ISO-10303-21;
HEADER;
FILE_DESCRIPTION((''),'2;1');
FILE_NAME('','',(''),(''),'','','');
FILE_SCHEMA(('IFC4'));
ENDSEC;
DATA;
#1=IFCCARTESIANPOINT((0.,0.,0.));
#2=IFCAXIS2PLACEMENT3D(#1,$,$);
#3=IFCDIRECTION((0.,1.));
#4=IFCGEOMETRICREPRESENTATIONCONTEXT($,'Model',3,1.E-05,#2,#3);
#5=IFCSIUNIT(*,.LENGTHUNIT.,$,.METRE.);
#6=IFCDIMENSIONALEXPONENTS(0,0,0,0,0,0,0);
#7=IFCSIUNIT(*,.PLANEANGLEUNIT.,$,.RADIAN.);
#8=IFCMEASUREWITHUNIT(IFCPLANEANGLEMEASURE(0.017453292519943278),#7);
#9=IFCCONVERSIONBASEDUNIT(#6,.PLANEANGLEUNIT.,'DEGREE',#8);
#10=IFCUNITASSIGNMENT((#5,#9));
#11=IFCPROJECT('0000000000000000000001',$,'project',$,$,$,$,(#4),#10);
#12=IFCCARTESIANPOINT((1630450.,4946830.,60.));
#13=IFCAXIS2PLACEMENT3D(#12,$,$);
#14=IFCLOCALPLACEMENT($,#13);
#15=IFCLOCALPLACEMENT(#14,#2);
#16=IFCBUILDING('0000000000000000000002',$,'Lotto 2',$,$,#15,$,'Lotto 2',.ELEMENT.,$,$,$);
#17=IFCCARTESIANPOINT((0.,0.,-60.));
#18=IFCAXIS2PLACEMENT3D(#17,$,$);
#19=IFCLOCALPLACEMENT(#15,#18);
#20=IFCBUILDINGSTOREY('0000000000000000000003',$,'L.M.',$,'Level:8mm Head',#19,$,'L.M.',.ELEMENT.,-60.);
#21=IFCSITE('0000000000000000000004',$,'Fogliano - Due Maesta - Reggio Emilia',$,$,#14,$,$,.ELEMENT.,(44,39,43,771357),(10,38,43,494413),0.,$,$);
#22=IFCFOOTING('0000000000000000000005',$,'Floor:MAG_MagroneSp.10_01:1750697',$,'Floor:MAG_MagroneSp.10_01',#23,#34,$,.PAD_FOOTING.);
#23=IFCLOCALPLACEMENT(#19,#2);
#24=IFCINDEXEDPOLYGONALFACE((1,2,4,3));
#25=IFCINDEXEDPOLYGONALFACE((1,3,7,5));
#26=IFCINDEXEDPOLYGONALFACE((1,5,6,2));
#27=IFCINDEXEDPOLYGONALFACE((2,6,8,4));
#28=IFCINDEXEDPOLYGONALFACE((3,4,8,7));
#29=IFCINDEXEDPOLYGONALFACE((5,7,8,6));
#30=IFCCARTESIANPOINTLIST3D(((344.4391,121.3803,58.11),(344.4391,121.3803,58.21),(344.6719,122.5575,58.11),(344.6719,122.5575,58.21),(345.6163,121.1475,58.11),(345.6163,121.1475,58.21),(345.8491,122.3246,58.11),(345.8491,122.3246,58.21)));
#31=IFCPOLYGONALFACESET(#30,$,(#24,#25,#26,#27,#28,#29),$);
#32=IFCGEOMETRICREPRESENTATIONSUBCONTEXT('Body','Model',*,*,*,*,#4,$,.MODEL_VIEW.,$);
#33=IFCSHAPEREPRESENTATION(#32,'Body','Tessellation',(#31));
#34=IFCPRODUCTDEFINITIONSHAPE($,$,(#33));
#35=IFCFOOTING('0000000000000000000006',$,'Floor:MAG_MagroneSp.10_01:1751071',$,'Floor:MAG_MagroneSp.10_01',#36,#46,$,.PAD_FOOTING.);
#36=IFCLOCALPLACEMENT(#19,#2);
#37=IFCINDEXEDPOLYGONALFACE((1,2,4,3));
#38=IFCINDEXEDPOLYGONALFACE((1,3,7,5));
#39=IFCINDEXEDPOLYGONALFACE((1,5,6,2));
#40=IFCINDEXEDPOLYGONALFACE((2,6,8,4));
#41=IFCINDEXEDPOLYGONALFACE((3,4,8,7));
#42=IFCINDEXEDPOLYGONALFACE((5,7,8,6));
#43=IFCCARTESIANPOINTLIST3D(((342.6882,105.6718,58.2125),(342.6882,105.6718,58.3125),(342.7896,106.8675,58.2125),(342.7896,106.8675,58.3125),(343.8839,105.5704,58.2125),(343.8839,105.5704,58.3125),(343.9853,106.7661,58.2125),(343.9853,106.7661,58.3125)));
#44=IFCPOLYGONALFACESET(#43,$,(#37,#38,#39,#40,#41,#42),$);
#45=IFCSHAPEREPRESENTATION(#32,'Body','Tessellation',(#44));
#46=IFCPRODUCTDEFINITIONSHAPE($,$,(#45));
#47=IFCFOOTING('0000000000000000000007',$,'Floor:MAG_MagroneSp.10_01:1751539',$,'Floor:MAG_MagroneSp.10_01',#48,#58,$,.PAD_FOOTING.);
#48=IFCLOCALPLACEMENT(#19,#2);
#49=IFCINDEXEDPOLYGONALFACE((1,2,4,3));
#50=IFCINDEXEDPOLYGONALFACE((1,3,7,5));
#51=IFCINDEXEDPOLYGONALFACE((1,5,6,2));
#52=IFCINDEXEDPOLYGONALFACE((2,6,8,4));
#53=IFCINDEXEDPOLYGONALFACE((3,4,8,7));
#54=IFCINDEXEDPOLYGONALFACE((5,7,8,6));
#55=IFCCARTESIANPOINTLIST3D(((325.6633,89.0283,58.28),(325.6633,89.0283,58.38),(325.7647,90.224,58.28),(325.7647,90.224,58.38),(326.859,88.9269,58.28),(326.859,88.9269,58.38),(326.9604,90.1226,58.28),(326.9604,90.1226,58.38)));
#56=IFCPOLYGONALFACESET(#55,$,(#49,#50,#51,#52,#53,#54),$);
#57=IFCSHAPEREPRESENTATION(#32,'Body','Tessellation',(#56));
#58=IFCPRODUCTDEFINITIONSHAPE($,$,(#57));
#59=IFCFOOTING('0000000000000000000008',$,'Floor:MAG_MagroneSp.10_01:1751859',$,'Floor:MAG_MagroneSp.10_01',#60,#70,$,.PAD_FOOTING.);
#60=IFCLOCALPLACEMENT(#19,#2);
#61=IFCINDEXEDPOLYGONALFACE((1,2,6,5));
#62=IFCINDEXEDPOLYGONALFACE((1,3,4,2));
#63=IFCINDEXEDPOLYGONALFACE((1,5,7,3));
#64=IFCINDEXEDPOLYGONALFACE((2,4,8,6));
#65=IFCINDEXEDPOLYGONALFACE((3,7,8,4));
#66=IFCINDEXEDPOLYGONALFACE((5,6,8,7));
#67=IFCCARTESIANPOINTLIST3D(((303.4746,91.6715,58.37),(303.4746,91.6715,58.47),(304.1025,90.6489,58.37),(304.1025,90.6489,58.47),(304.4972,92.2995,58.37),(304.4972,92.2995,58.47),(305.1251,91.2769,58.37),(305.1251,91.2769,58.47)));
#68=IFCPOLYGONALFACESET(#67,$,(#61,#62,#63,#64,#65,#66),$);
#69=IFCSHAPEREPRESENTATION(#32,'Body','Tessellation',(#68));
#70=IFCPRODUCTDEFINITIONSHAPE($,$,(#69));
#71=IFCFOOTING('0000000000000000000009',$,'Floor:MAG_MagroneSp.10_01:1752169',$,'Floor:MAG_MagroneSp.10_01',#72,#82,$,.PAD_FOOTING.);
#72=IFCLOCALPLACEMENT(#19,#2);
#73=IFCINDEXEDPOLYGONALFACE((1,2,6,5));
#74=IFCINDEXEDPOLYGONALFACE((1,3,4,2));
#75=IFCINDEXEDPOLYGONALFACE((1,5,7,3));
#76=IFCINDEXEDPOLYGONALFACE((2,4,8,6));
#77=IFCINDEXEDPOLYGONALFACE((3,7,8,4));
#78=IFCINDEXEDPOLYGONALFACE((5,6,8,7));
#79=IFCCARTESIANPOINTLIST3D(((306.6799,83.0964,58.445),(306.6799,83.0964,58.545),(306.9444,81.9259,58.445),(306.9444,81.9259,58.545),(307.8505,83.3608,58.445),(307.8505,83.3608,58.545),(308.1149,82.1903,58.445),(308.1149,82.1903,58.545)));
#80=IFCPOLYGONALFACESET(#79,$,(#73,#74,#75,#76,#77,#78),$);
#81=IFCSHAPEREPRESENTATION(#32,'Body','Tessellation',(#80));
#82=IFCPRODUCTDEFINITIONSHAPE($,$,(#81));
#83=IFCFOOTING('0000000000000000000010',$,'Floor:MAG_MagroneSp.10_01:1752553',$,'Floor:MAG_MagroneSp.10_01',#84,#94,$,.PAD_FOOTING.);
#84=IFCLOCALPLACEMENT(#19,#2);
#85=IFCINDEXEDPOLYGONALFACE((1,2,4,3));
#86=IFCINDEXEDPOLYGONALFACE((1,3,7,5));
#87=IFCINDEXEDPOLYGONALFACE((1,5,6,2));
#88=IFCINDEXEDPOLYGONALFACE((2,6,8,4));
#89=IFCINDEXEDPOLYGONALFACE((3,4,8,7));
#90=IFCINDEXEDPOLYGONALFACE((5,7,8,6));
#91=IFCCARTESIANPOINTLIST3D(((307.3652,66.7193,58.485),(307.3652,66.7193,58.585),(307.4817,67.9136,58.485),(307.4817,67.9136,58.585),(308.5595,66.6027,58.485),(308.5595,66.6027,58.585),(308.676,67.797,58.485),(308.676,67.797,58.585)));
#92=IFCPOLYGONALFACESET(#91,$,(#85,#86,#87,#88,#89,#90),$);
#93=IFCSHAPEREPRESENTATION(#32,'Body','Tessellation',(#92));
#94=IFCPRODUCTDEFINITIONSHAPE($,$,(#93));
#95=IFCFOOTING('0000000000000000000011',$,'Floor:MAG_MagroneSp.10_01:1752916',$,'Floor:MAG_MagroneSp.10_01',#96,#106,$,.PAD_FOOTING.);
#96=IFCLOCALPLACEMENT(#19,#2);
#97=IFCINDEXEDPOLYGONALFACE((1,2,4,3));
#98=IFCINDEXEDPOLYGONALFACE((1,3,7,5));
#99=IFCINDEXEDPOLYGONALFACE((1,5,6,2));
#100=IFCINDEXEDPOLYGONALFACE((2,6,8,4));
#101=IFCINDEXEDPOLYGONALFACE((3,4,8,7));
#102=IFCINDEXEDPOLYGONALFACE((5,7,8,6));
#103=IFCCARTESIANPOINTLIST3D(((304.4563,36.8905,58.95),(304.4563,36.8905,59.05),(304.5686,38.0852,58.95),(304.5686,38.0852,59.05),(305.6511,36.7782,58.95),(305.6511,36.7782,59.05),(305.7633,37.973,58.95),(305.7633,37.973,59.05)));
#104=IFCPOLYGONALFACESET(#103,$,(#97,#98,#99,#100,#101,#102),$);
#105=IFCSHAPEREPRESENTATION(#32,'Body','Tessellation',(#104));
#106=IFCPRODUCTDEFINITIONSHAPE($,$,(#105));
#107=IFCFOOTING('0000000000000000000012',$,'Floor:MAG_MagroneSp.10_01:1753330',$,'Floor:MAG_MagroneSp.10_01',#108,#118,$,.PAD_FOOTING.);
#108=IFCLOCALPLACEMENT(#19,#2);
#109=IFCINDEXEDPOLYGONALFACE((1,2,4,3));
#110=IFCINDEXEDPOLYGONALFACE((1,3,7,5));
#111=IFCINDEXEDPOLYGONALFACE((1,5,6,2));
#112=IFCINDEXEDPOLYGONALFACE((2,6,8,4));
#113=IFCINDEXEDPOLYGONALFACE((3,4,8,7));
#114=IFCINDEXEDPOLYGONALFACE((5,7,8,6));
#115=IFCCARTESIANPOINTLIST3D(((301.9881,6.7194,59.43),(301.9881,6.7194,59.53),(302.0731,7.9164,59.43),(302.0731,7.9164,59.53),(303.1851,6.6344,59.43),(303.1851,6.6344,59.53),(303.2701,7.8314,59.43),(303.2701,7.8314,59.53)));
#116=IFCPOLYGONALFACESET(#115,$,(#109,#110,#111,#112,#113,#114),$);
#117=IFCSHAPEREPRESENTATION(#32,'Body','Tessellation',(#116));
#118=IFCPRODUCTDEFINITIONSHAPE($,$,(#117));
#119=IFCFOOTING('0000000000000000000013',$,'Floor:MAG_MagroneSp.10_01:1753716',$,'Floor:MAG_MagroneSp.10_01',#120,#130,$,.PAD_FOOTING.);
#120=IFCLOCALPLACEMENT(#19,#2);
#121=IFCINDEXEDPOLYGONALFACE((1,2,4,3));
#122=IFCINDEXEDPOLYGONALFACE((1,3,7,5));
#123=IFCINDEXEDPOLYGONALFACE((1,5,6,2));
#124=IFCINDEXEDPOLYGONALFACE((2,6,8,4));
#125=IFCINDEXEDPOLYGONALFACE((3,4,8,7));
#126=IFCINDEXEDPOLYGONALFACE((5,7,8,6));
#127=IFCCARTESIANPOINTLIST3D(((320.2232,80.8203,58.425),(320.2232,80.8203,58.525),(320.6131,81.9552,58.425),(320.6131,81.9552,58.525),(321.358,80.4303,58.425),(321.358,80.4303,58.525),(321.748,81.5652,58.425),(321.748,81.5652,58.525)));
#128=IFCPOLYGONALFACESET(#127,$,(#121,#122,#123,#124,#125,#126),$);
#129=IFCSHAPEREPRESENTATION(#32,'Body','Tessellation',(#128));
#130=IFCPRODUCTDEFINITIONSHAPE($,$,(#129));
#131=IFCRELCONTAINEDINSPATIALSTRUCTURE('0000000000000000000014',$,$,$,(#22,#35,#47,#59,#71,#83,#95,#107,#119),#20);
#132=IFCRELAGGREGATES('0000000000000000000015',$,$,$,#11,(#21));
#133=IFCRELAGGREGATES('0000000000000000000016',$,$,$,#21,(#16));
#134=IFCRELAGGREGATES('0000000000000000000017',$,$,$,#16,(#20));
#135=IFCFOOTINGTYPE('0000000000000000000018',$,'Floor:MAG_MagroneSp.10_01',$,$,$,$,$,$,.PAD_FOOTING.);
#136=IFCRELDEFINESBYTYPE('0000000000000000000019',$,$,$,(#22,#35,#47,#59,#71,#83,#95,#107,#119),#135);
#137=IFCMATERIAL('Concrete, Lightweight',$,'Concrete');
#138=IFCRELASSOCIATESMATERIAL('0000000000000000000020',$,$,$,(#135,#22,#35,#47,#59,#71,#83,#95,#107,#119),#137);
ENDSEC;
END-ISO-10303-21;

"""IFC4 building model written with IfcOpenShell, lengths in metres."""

from ifc_helpers import new_model, entity, si_unit, converted_unit, direction, frame, origin, place, context, subcontext, project, spatial, indexed_curve, outline, extrude, material, type_object, element, save


model = new_model("IFC4")

# Units and contexts
model_context = context("Model", 3, precision=1e-05, world=origin(), true_north=direction((0.0, 1.0)))
body_context = subcontext(model_context, "Body", "Model", "MODEL_VIEW")
ifc_project = project(units=[si_unit("LENGTHUNIT", "METRE"), converted_unit("PLANEANGLEUNIT", "DEGREE", entity("IfcPlaneAngleMeasure", 0.017453292519943278), si_unit("PLANEANGLEUNIT", "RADIAN"), dimensions=[0, 0, 0, 0, 0, 0, 0])], contexts=[model_context])

# Site, building, storey
site_placement = place(None, frame((1630450.0, 4946830.0, 60.0)))
site = spatial("IfcSite", under=ifc_project, at=site_placement, Name="Fogliano - Due Maesta - Reggio Emilia", CompositionType="ELEMENT", RefLatitude=(44, 39, 43, 771357), RefLongitude=(10, 38, 43, 494413), RefElevation=0.0)
building_placement = place(site_placement, origin())
building = spatial("IfcBuilding", under=site, at=building_placement, Name="Lotto 2", LongName="Lotto 2", CompositionType="ELEMENT")
storey_placement = place(building_placement, frame((0.0, 0.0, -60.0)))
storey = spatial("IfcBuildingStorey", under=building, at=storey_placement, Name="L.M.", ObjectType="Level:8mm Head", LongName="L.M.", CompositionType="ELEMENT", Elevation=-60.0)

# Footings
ifc_material = material(Name="Concrete, Lightweight", Category="Concrete")
footing_type = type_object("IfcFootingType", Name="Floor:MAG_MagroneSp.10_01", PredefinedType="PAD_FOOTING", material=ifc_material)
footing_1_placement = place(storey_placement, origin())
element("IfcFooting", 1, at=footing_1_placement, inside=storey, type_object=footing_type, material=ifc_material, Name="Floor:MAG_MagroneSp.10_01:1750697", ObjectType="Floor:MAG_MagroneSp.10_01", PredefinedType="PAD_FOOTING", context=body_context, shape_type="SweptSolid", body=[
    extrude(outline(indexed_curve([(-0.6, -0.6), (0.6, -0.6), (0.6, 0.6), (-0.6, 0.6), (-0.6, -0.6)], self_intersect=False)), frame((345.1441, 121.8525, 58.21), z_axis=(0.0, 0.0, -1.0), x_axis=(-0.194039, -0.980994, 0.0)), (0.0, 0.0, 1.0), 0.1),
])
footing_2_placement = place(storey_placement, origin())
element("IfcFooting", 2, at=footing_2_placement, inside=storey, type_object=footing_type, material=ifc_material, Name="Floor:MAG_MagroneSp.10_01:1751071", ObjectType="Floor:MAG_MagroneSp.10_01", PredefinedType="PAD_FOOTING", context=body_context, shape_type="SweptSolid", body=[
    extrude(outline(indexed_curve([(-0.6, -0.6), (0.6, -0.6), (0.6, 0.6), (-0.6, 0.6), (-0.6, -0.6)], self_intersect=False)), frame((343.3367, 106.2189, 58.3125), z_axis=(0.0, 0.0, -1.0), x_axis=(-0.084482, -0.996425, 0.0)), (0.0, 0.0, 1.0), 0.1),
])
footing_3_placement = place(storey_placement, origin())
element("IfcFooting", 3, at=footing_3_placement, inside=storey, type_object=footing_type, material=ifc_material, Name="Floor:MAG_MagroneSp.10_01:1751539", ObjectType="Floor:MAG_MagroneSp.10_01", PredefinedType="PAD_FOOTING", context=body_context, shape_type="SweptSolid", body=[
    extrude(outline(indexed_curve([(-0.6, -0.6), (0.6, -0.6), (0.6, 0.6), (-0.6, 0.6), (-0.6, -0.6)], self_intersect=False)), frame((326.3118, 89.5755, 58.38), z_axis=(0.0, 0.0, -1.0), x_axis=(-0.084482, -0.996425, 0.0)), (0.0, 0.0, 1.0), 0.1),
])
footing_4_placement = place(storey_placement, origin())
element("IfcFooting", 4, at=footing_4_placement, inside=storey, type_object=footing_type, material=ifc_material, Name="Floor:MAG_MagroneSp.10_01:1751859", ObjectType="Floor:MAG_MagroneSp.10_01", PredefinedType="PAD_FOOTING", context=body_context, shape_type="SweptSolid", body=[
    extrude(outline(indexed_curve([(-0.6, -0.6), (0.6, -0.6), (0.6, 0.6), (-0.6, 0.6), (-0.6, -0.6)], self_intersect=False)), frame((304.2999, 91.4742, 58.47), z_axis=(0.0, 0.0, -1.0), x_axis=(0.523263, -0.852171, 0.0)), (0.0, 0.0, 1.0), 0.1),
])
footing_5_placement = place(storey_placement, origin())
element("IfcFooting", 5, at=footing_5_placement, inside=storey, type_object=footing_type, material=ifc_material, Name="Floor:MAG_MagroneSp.10_01:1752169", ObjectType="Floor:MAG_MagroneSp.10_01", PredefinedType="PAD_FOOTING", context=body_context, shape_type="SweptSolid", body=[
    extrude(outline(indexed_curve([(-0.6, -0.6), (0.6, -0.6), (0.6, 0.6), (-0.6, 0.6), (-0.6, -0.6)], self_intersect=False)), frame((307.3974, 82.6434, 58.545), z_axis=(0.0, 0.0, -1.0), x_axis=(0.220341, -0.975423, 0.0)), (0.0, 0.0, 1.0), 0.1),
])
footing_6_placement = place(storey_placement, origin())
element("IfcFooting", 6, at=footing_6_placement, inside=storey, type_object=footing_type, material=ifc_material, Name="Floor:MAG_MagroneSp.10_01:1752553", ObjectType="Floor:MAG_MagroneSp.10_01", PredefinedType="PAD_FOOTING", context=body_context, shape_type="SweptSolid", body=[
    extrude(outline(indexed_curve([(-0.6, -0.6), (0.6, -0.6), (0.6, 0.6), (-0.6, 0.6), (-0.6, -0.6)], self_intersect=False)), frame((308.0206, 67.2581, 58.585), z_axis=(0.0, 0.0, -1.0), x_axis=(-0.097129, -0.995272, 0.0)), (0.0, 0.0, 1.0), 0.1),
])
footing_7_placement = place(storey_placement, origin())
element("IfcFooting", 7, at=footing_7_placement, inside=storey, type_object=footing_type, material=ifc_material, Name="Floor:MAG_MagroneSp.10_01:1752916", ObjectType="Floor:MAG_MagroneSp.10_01", PredefinedType="PAD_FOOTING", context=body_context, shape_type="SweptSolid", body=[
    extrude(outline(indexed_curve([(-0.6, -0.6), (0.6, -0.6), (0.6, 0.6), (-0.6, 0.6), (-0.6, -0.6)], self_intersect=False)), frame((305.1098, 37.4317, 59.05), z_axis=(0.0, 0.0, -1.0), x_axis=(-0.093547, -0.995615, 0.0)), (0.0, 0.0, 1.0), 0.1),
])
footing_8_placement = place(storey_placement, origin())
element("IfcFooting", 8, at=footing_8_placement, inside=storey, type_object=footing_type, material=ifc_material, Name="Floor:MAG_MagroneSp.10_01:1753330", ObjectType="Floor:MAG_MagroneSp.10_01", PredefinedType="PAD_FOOTING", context=body_context, shape_type="SweptSolid", body=[
    extrude(outline(indexed_curve([(-0.6, -0.6), (0.6, -0.6), (0.6, 0.6), (-0.6, 0.6), (-0.6, -0.6)], self_intersect=False)), frame((302.6291, 7.2754, 59.53), z_axis=(0.0, 0.0, -1.0), x_axis=(-0.070823, -0.997489, 0.0)), (0.0, 0.0, 1.0), 0.1),
])
footing_9_placement = place(storey_placement, origin())
element("IfcFooting", 9, at=footing_9_placement, inside=storey, type_object=footing_type, material=ifc_material, Name="Floor:MAG_MagroneSp.10_01:1753716", ObjectType="Floor:MAG_MagroneSp.10_01", PredefinedType="PAD_FOOTING", context=body_context, shape_type="SweptSolid", body=[
    extrude(outline(indexed_curve([(-0.6, -0.6), (0.6, -0.6), (0.6, 0.6), (-0.6, 0.6), (-0.6, -0.6)], self_intersect=False)), frame((320.9856, 81.1928, 58.525), z_axis=(0.0, 0.0, -1.0), x_axis=(-0.324977, -0.945722, 0.0)), (0.0, 0.0, 1.0), 0.1),
])

save(model, "model.ifc")
